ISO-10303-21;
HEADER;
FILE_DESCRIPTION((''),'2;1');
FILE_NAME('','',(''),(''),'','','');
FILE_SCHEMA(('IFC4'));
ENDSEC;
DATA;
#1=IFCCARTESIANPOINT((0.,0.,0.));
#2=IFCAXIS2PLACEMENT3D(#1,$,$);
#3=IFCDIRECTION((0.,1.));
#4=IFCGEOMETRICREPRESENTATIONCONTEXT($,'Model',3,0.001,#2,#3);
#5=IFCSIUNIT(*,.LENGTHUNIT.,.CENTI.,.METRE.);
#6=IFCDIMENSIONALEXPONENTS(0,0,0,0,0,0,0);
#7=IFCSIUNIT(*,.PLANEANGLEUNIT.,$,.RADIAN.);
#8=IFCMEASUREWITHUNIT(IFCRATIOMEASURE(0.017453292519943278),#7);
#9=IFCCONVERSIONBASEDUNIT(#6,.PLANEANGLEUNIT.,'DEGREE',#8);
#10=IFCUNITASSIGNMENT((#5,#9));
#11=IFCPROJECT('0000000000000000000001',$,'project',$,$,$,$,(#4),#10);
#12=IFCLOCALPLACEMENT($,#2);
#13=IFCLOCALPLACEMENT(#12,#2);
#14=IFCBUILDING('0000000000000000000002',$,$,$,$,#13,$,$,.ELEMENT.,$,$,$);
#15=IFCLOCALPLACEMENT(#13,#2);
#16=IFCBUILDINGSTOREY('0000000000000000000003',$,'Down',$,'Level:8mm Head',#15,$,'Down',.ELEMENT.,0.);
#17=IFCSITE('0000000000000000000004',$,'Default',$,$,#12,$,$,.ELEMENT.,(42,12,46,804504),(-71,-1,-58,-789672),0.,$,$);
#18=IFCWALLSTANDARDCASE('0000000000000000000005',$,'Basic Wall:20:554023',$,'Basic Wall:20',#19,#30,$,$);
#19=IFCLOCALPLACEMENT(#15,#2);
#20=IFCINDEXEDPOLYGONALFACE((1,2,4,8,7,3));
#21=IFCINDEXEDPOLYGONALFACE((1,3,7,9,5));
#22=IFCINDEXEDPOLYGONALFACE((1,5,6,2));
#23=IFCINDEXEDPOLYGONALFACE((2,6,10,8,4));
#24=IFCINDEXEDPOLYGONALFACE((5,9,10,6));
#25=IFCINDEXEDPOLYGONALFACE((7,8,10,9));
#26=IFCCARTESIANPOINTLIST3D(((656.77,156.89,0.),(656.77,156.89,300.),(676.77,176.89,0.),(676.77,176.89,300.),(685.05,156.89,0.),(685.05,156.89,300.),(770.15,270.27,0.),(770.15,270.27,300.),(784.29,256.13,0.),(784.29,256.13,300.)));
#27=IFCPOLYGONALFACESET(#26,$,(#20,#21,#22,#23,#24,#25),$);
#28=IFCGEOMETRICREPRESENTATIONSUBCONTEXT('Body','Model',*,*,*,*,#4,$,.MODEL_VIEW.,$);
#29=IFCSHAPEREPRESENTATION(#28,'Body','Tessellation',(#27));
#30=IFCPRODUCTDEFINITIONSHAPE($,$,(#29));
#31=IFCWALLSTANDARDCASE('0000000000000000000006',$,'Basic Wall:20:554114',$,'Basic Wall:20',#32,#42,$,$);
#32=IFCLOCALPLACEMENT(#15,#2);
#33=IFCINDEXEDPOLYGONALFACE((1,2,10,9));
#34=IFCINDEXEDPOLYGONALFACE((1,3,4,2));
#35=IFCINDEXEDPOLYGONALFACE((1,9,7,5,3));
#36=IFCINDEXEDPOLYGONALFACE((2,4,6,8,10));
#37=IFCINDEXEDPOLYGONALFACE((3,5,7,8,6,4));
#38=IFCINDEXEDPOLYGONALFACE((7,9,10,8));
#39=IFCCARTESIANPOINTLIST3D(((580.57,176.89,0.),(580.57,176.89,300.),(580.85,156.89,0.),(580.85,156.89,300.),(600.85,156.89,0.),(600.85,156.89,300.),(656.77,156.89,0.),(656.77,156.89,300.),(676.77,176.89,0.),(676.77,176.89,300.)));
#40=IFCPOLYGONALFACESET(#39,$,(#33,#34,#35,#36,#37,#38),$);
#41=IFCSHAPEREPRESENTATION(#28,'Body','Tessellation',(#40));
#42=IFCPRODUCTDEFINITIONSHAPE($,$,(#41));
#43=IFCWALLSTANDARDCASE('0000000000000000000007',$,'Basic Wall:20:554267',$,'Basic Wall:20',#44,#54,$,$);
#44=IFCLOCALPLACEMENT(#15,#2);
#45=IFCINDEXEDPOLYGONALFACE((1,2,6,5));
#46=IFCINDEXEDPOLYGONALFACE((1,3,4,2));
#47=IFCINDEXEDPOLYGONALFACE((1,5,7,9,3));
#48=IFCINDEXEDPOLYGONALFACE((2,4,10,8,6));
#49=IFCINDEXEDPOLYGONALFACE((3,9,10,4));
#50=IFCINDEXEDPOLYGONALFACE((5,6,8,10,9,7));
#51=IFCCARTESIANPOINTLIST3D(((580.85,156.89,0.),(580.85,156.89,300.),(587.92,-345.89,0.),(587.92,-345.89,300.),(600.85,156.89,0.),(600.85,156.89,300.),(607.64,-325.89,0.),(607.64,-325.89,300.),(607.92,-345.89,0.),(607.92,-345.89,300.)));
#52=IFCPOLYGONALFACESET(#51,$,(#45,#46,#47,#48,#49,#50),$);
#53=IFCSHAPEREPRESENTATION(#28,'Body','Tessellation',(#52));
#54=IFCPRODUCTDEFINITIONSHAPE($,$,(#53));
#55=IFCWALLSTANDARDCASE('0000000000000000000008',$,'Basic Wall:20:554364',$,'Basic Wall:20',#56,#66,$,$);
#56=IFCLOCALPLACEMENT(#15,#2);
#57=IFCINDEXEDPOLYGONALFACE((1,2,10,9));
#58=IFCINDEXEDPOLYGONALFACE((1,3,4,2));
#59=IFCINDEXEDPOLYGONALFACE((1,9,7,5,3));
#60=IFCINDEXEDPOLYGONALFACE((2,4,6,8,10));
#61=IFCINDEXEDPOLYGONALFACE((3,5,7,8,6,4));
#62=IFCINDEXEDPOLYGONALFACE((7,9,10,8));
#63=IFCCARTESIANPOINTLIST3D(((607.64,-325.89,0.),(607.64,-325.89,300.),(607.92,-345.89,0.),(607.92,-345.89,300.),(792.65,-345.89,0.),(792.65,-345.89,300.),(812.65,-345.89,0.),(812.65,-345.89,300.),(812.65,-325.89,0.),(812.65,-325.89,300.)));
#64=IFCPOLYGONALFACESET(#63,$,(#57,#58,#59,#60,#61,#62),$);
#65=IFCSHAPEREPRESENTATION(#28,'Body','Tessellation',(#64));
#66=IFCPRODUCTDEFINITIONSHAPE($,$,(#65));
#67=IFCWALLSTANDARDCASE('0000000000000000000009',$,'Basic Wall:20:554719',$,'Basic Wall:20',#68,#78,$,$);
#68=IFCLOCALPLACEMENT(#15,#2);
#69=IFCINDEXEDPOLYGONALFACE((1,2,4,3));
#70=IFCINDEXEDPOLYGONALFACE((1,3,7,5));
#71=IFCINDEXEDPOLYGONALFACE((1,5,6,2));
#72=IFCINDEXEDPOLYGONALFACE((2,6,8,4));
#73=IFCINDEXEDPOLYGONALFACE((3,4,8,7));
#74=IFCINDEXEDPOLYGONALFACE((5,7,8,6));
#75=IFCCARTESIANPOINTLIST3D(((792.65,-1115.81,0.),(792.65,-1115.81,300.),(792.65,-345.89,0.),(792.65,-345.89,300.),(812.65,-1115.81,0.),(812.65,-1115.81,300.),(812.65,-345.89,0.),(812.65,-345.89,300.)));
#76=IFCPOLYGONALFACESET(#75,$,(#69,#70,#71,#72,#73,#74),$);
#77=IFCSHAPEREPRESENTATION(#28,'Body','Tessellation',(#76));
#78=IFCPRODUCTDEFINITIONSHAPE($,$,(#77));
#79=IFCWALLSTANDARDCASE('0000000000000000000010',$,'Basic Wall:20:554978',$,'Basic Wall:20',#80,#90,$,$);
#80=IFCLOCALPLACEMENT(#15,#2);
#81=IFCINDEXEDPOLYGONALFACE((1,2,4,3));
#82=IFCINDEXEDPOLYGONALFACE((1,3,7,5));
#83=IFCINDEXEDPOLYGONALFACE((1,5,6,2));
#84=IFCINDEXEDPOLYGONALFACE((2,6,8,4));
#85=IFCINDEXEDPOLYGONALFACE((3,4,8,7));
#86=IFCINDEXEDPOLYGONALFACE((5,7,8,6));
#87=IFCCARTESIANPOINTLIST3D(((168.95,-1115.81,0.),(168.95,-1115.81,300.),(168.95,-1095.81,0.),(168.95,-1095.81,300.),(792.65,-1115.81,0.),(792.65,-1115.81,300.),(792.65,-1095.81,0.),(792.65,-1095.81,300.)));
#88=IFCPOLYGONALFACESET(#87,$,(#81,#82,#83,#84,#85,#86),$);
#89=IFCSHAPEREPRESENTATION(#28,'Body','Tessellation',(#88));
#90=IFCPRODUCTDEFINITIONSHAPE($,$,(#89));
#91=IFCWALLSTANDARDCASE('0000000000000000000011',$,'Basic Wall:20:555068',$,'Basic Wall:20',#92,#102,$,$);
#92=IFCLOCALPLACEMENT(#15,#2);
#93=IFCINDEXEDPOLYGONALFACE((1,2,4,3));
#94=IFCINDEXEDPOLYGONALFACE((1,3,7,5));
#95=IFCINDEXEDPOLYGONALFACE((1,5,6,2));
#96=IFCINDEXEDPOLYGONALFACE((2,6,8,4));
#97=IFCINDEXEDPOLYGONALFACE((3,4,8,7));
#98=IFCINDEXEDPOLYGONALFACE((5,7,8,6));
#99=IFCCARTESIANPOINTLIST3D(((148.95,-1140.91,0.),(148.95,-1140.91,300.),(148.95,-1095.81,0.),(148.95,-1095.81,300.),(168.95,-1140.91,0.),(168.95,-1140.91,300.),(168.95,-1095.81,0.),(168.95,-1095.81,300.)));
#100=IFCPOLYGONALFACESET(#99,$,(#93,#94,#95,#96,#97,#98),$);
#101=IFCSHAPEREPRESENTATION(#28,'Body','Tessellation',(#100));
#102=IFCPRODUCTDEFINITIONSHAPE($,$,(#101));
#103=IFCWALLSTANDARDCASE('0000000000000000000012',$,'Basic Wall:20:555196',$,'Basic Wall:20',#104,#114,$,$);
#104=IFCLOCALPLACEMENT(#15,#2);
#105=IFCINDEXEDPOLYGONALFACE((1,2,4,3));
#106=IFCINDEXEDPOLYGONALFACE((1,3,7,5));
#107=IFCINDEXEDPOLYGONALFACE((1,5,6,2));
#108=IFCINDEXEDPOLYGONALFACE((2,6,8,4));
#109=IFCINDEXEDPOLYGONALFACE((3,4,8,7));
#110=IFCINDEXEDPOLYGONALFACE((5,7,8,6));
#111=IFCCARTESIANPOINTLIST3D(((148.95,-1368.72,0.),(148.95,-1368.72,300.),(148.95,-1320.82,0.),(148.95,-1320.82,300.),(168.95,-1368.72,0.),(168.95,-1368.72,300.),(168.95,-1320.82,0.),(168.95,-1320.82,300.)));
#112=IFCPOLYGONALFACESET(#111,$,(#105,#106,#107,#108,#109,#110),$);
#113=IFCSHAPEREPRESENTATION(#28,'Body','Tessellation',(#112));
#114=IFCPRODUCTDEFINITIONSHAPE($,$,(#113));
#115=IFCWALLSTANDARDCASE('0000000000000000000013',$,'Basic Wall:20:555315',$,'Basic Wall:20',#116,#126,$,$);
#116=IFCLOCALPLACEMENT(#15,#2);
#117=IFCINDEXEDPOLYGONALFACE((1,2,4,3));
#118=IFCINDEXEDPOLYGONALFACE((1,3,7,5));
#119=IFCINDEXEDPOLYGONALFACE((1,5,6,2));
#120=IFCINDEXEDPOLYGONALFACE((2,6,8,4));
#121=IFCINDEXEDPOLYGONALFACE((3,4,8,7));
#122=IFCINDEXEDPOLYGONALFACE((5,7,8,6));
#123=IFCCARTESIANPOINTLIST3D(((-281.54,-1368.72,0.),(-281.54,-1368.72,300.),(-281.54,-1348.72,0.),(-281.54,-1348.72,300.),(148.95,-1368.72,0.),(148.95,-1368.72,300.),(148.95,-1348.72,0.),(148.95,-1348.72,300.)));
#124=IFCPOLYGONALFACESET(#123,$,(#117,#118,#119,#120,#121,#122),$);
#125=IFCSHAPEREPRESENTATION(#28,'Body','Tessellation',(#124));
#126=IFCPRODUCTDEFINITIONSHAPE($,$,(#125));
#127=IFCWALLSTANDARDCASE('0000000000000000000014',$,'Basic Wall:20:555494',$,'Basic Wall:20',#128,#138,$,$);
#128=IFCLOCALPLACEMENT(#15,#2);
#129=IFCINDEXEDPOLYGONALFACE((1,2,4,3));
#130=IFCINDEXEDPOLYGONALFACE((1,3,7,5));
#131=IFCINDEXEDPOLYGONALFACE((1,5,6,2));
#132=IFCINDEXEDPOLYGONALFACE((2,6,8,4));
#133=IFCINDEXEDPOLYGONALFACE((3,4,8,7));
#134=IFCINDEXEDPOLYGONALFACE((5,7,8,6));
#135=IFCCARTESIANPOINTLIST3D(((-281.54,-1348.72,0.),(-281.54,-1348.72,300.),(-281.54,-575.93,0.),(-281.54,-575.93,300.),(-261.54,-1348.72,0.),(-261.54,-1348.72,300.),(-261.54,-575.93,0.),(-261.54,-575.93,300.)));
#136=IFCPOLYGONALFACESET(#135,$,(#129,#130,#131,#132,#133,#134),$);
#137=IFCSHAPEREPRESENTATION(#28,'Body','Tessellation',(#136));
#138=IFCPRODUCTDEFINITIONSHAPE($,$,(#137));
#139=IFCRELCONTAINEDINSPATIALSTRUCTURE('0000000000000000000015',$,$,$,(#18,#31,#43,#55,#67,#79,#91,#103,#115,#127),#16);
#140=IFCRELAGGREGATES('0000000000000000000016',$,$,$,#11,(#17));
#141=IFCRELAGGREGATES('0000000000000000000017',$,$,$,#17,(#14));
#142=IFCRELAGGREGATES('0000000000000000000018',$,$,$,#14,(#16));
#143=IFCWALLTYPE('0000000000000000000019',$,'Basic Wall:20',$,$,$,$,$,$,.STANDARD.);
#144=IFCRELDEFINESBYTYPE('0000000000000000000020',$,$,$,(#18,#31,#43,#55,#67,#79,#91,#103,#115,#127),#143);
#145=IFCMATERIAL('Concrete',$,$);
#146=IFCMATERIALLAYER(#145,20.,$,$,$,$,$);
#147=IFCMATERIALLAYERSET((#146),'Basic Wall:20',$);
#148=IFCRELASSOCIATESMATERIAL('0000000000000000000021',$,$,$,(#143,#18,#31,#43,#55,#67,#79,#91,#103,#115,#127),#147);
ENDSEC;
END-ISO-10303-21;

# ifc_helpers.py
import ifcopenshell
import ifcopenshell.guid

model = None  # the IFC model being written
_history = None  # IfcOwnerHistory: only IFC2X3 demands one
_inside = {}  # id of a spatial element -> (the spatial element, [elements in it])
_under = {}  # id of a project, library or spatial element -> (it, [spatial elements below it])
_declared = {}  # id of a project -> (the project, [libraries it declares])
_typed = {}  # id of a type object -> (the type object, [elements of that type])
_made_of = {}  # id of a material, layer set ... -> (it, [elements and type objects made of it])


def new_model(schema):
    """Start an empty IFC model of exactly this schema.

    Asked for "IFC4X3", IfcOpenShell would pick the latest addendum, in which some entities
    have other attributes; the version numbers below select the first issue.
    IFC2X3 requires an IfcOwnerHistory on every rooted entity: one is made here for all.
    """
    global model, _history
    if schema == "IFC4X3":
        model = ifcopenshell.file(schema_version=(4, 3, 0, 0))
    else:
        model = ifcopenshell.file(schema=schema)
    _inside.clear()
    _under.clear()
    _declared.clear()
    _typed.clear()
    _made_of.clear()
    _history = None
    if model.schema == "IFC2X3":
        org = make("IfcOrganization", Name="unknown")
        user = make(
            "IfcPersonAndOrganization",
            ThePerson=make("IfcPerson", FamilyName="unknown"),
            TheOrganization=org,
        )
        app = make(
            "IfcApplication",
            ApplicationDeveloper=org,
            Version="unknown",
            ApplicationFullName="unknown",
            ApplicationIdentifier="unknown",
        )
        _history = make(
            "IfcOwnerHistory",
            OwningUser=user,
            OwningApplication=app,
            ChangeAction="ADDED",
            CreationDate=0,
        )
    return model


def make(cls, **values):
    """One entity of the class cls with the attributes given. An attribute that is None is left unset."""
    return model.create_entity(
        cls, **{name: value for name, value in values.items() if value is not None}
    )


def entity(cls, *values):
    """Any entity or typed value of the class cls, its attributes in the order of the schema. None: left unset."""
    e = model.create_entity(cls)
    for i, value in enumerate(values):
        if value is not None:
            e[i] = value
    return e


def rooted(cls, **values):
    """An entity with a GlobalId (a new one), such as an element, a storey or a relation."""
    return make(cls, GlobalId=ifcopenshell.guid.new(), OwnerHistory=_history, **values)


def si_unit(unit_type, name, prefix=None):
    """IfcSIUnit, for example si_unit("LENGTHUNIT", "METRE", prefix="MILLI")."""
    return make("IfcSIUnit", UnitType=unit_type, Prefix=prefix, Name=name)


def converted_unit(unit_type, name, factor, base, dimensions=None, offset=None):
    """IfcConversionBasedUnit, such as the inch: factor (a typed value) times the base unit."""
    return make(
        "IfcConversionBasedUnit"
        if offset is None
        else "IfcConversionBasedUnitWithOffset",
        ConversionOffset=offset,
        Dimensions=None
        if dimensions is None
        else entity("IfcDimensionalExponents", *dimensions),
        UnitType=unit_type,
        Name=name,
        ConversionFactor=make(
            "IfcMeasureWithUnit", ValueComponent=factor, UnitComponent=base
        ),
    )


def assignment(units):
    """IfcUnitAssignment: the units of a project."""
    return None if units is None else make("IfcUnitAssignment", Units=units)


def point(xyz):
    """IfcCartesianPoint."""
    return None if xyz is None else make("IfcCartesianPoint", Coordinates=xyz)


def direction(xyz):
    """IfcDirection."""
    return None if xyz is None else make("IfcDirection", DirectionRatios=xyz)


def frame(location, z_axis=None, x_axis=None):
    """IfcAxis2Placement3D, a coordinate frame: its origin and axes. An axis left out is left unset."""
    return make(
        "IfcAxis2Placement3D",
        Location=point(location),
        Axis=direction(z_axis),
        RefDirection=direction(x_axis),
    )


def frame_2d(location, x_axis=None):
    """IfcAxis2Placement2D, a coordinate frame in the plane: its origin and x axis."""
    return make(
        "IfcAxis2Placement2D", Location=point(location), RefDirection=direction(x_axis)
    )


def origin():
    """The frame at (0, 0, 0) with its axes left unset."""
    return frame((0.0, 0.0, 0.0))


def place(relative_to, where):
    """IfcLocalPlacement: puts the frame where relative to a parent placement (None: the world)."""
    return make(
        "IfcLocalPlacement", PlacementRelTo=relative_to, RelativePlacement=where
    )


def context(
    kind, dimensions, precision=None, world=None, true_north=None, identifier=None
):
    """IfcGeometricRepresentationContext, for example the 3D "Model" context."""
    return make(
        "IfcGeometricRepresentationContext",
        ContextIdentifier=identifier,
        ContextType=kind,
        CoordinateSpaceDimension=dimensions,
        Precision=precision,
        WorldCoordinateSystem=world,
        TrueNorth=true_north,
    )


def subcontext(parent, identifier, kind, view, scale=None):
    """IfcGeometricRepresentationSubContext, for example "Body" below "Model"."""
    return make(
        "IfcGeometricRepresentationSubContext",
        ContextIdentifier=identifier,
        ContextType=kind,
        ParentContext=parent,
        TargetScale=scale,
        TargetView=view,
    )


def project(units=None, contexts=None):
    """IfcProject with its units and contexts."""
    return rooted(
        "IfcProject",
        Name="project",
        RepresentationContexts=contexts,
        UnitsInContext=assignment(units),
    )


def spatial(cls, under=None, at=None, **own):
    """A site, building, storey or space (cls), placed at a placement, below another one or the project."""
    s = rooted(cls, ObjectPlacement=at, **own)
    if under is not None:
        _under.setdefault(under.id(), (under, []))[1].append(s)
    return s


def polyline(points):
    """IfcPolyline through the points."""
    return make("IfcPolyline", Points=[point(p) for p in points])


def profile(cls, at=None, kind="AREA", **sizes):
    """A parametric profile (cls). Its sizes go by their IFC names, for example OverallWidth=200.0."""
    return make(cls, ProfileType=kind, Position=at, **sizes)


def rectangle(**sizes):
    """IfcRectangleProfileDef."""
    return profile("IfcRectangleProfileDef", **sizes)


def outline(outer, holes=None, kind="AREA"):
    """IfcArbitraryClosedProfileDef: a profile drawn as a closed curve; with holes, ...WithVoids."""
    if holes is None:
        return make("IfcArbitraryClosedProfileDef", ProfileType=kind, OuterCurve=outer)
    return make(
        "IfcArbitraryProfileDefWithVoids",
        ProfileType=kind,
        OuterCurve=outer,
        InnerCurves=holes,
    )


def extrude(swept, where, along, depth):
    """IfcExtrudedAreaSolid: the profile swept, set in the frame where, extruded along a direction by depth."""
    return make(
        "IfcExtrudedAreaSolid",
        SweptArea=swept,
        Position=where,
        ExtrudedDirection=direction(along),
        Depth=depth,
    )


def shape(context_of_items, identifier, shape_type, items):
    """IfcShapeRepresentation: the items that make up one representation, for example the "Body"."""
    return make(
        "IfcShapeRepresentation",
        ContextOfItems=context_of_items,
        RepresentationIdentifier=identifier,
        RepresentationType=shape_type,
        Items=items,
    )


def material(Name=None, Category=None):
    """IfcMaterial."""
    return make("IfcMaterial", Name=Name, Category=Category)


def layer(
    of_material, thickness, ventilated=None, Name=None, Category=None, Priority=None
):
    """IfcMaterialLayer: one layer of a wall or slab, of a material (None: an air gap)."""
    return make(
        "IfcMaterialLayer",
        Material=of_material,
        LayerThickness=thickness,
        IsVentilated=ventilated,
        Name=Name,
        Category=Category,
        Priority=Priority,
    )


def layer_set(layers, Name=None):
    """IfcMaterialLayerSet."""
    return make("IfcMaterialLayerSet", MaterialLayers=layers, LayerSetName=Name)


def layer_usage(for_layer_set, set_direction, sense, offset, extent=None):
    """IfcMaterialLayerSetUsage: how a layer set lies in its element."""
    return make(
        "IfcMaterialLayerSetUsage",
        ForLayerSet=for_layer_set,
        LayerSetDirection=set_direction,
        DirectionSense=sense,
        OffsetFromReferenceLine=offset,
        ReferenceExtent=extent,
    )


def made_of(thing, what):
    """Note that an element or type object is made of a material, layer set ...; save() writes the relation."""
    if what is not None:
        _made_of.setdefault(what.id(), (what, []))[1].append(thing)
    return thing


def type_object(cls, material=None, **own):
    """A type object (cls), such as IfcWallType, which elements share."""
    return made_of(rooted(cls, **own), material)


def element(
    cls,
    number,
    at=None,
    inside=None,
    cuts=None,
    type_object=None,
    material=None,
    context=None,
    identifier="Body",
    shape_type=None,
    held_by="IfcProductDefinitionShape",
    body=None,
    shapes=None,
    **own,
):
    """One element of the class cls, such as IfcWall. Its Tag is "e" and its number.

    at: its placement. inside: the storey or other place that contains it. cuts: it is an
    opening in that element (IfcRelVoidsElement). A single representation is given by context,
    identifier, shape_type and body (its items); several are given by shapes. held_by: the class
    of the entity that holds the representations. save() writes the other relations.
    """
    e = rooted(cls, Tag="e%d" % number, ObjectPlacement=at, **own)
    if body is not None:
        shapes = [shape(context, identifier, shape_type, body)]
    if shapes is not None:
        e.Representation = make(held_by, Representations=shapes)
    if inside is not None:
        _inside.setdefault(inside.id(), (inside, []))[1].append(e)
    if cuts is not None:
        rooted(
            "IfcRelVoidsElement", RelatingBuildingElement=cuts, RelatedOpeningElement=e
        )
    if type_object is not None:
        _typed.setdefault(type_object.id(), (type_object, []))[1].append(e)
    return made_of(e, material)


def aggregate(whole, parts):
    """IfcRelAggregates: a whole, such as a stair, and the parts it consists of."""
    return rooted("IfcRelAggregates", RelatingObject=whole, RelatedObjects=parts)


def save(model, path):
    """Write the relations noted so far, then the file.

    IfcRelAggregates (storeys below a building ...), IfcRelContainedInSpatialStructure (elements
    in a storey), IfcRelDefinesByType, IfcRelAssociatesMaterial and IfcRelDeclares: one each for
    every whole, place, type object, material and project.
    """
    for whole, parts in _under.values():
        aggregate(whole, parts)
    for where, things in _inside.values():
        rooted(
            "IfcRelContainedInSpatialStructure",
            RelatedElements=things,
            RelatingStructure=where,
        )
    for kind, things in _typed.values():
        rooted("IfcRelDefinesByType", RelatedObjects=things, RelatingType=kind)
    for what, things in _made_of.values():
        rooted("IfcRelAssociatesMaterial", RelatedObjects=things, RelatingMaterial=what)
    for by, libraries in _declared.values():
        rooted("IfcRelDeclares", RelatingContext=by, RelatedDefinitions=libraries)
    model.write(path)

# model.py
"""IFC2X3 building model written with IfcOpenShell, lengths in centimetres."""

from ifc_helpers import new_model, entity, si_unit, converted_unit, direction, frame, frame_2d, origin, place, context, subcontext, project, spatial, polyline, rectangle, outline, extrude, material, layer, layer_set, layer_usage, type_object, element, save


model = new_model("IFC2X3")

# Units and contexts
model_context = context("Model", 3, precision=0.001, world=origin(), true_north=direction((0.0, 1.0)))
body_context = subcontext(model_context, "Body", "Model", "MODEL_VIEW")
ifc_project = project(units=[si_unit("LENGTHUNIT", "METRE", prefix="CENTI"), converted_unit("PLANEANGLEUNIT", "DEGREE", entity("IfcRatioMeasure", 0.017453292519943278), si_unit("PLANEANGLEUNIT", "RADIAN"), dimensions=[0, 0, 0, 0, 0, 0, 0])], contexts=[model_context])

# Site, building, storey
site_placement = place(None, origin())
site = spatial("IfcSite", under=ifc_project, at=site_placement, Name="Default", CompositionType="ELEMENT", RefLatitude=(42, 12, 46, 804504), RefLongitude=(-71, -1, -58, -789672), RefElevation=0.0)
building_placement = place(site_placement, origin())
building = spatial("IfcBuilding", under=site, at=building_placement, CompositionType="ELEMENT")
storey_placement = place(building_placement, origin())
storey = spatial("IfcBuildingStorey", under=building, at=storey_placement, Name="Down", ObjectType="Level:8mm Head", LongName="Down", CompositionType="ELEMENT", Elevation=0.0)

# Shared definitions
ifc_material = material(Name="Concrete")

# Walls
ifc_layer_1 = layer(ifc_material, 20.0)
ifc_layer_set_1 = layer_set([ifc_layer_1], Name="Basic Wall:20")
wall_type_1 = type_object("IfcWallType", Name="Basic Wall:20", PredefinedType="STANDARD", material=ifc_layer_set_1)
ifc_layer_usage_1 = layer_usage(ifc_layer_set_1, "AXIS2", "POSITIVE", -10.0)
wall_1_placement = place(storey_placement, frame((777.22, 263.2, 0.0), z_axis=(0.0, 0.0, 1.0), x_axis=(-0.707107, -0.707107, 0.0)))
element("IfcWallStandardCase", 1, at=wall_1_placement, inside=storey, type_object=wall_type_1, material=ifc_layer_usage_1, Name="Basic Wall:20:554023", ObjectType="Basic Wall:20", context=body_context, shape_type="SweptSolid", body=[
    extrude(outline(polyline([(160.35, -10.0), (140.35, 10.0), (0.0, 10.0), (0.0, -10.0), (132.07, -10.0), (160.35, -10.0)])), origin(), (0.0, 0.0, 1.0), 300.0),
])
ifc_layer_usage_2 = layer_usage(ifc_layer_set_1, "AXIS2", "POSITIVE", -10.0)
wall_2_placement = place(storey_placement, frame((676.77, 166.89, 0.0), z_axis=(0.0, 0.0, 1.0), x_axis=(-1.0, 0.0, 0.0)))
element("IfcWallStandardCase", 2, at=wall_2_placement, inside=storey, type_object=wall_type_1, material=ifc_layer_usage_2, Name="Basic Wall:20:554114", ObjectType="Basic Wall:20", context=body_context, shape_type="SweptSolid", body=[
    extrude(outline(polyline([(96.2, -10.0), (95.92, 10.0), (75.92, 10.0), (20.0, 10.0), (0.0, -10.0), (96.2, -10.0)])), origin(), (0.0, 0.0, 1.0), 300.0),
])
ifc_layer_usage_3 = layer_usage(ifc_layer_set_1, "AXIS2", "POSITIVE", -10.0)
wall_3_placement = place(storey_placement, frame((590.85, 157.03, 0.0), z_axis=(0.0, 0.0, 1.0), x_axis=(0.014061, -0.999901, 0.0)))
element("IfcWallStandardCase", 3, at=wall_3_placement, inside=storey, type_object=wall_type_1, material=ifc_layer_usage_3, Name="Basic Wall:20:554267", ObjectType="Basic Wall:20", context=body_context, shape_type="SweptSolid", body=[
    extrude(outline(polyline([(502.83, -10.0), (503.11, 10.0), (483.11, 10.0), (0.28, 10.0), (0.0, -10.0), (502.83, -10.0)])), origin(), (0.0, 0.0, 1.0), 300.0),
])
ifc_layer_usage_4 = layer_usage(ifc_layer_set_1, "AXIS2", "POSITIVE", -10.0)
wall_4_placement = place(storey_placement, frame((607.64, -335.89, 0.0)))
element("IfcWallStandardCase", 4, at=wall_4_placement, inside=storey, type_object=wall_type_1, material=ifc_layer_usage_4, Name="Basic Wall:20:554364", ObjectType="Basic Wall:20", context=body_context, shape_type="SweptSolid", body=[
    extrude(outline(polyline([(205.01, -10.0), (205.01, 10.0), (0.0, 10.0), (0.28, -10.0), (185.01, -10.0), (205.01, -10.0)])), origin(), (0.0, 0.0, 1.0), 300.0),
])
ifc_layer_usage_5 = layer_usage(ifc_layer_set_1, "AXIS2", "POSITIVE", -10.0)
wall_5_placement = place(storey_placement, frame((802.65, -345.89, 0.0), z_axis=(0.0, 0.0, 1.0), x_axis=(0.0, -1.0, 0.0)))
element("IfcWallStandardCase", 5, at=wall_5_placement, inside=storey, type_object=wall_type_1, material=ifc_layer_usage_5, Name="Basic Wall:20:554719", ObjectType="Basic Wall:20", context=body_context, shape_type="SweptSolid", body=[
    extrude(rectangle(XDim=769.92, YDim=20.0, at=frame_2d((384.96, 0.0), x_axis=(-1.0, 0.0))), origin(), (0.0, 0.0, 1.0), 300.0),
])
ifc_layer_usage_6 = layer_usage(ifc_layer_set_1, "AXIS2", "NEGATIVE", 10.0)
wall_6_placement = place(storey_placement, frame((792.65, -1105.81, 0.0), z_axis=(0.0, 0.0, 1.0), x_axis=(-1.0, 0.0, 0.0)))
element("IfcWallStandardCase", 6, at=wall_6_placement, inside=storey, type_object=wall_type_1, material=ifc_layer_usage_6, Name="Basic Wall:20:554978", ObjectType="Basic Wall:20", context=body_context, shape_type="SweptSolid", body=[
    extrude(rectangle(XDim=623.7, YDim=20.0, at=frame_2d((311.85, 0.0), x_axis=(-1.0, 0.0))), origin(), (0.0, 0.0, 1.0), 300.0),
])
ifc_layer_usage_7 = layer_usage(ifc_layer_set_1, "AXIS2", "NEGATIVE", 10.0)
wall_7_placement = place(storey_placement, frame((158.95, -1095.81, 0.0), z_axis=(0.0, 0.0, 1.0), x_axis=(0.0, -1.0, 0.0)))
element("IfcWallStandardCase", 7, at=wall_7_placement, inside=storey, type_object=wall_type_1, material=ifc_layer_usage_7, Name="Basic Wall:20:555068", ObjectType="Basic Wall:20", context=body_context, shape_type="SweptSolid", body=[
    extrude(rectangle(XDim=45.1, YDim=20.0, at=frame_2d((22.55, 0.0), x_axis=(-1.0, 0.0))), origin(), (0.0, 0.0, 1.0), 300.0),
])
ifc_layer_usage_8 = layer_usage(ifc_layer_set_1, "AXIS2", "NEGATIVE", 10.0)
wall_8_placement = place(storey_placement, frame((158.95, -1320.82, 0.0), z_axis=(0.0, 0.0, 1.0), x_axis=(0.0, -1.0, 0.0)))
element("IfcWallStandardCase", 8, at=wall_8_placement, inside=storey, type_object=wall_type_1, material=ifc_layer_usage_8, Name="Basic Wall:20:555196", ObjectType="Basic Wall:20", context=body_context, shape_type="SweptSolid", body=[
    extrude(rectangle(XDim=47.9, YDim=20.0, at=frame_2d((23.95, 0.0), x_axis=(-1.0, 0.0))), origin(), (0.0, 0.0, 1.0), 300.0),
])
ifc_layer_usage_9 = layer_usage(ifc_layer_set_1, "AXIS2", "NEGATIVE", 10.0)
wall_9_placement = place(storey_placement, frame((148.95, -1358.72, 0.0), z_axis=(0.0, 0.0, 1.0), x_axis=(-1.0, 0.0, 0.0)))
element("IfcWallStandardCase", 9, at=wall_9_placement, inside=storey, type_object=wall_type_1, material=ifc_layer_usage_9, Name="Basic Wall:20:555315", ObjectType="Basic Wall:20", context=body_context, shape_type="SweptSolid", body=[
    extrude(rectangle(XDim=430.5, YDim=20.0, at=frame_2d((215.25, 0.0), x_axis=(-1.0, 0.0))), origin(), (0.0, 0.0, 1.0), 300.0),
])
ifc_layer_usage_10 = layer_usage(ifc_layer_set_1, "AXIS2", "NEGATIVE", 10.0)
wall_10_placement = place(storey_placement, frame((-271.54, -1348.72, 0.0), z_axis=(0.0, 0.0, 1.0), x_axis=(0.0, 1.0, 0.0)))
element("IfcWallStandardCase", 10, at=wall_10_placement, inside=storey, type_object=wall_type_1, material=ifc_layer_usage_10, Name="Basic Wall:20:555494", ObjectType="Basic Wall:20", context=body_context, shape_type="SweptSolid", body=[
    extrude(rectangle(XDim=772.79, YDim=20.0, at=frame_2d((386.39, 0.0), x_axis=(-1.0, 0.0))), origin(), (0.0, 0.0, 1.0), 300.0),
])

save(model, "model.ifc")
